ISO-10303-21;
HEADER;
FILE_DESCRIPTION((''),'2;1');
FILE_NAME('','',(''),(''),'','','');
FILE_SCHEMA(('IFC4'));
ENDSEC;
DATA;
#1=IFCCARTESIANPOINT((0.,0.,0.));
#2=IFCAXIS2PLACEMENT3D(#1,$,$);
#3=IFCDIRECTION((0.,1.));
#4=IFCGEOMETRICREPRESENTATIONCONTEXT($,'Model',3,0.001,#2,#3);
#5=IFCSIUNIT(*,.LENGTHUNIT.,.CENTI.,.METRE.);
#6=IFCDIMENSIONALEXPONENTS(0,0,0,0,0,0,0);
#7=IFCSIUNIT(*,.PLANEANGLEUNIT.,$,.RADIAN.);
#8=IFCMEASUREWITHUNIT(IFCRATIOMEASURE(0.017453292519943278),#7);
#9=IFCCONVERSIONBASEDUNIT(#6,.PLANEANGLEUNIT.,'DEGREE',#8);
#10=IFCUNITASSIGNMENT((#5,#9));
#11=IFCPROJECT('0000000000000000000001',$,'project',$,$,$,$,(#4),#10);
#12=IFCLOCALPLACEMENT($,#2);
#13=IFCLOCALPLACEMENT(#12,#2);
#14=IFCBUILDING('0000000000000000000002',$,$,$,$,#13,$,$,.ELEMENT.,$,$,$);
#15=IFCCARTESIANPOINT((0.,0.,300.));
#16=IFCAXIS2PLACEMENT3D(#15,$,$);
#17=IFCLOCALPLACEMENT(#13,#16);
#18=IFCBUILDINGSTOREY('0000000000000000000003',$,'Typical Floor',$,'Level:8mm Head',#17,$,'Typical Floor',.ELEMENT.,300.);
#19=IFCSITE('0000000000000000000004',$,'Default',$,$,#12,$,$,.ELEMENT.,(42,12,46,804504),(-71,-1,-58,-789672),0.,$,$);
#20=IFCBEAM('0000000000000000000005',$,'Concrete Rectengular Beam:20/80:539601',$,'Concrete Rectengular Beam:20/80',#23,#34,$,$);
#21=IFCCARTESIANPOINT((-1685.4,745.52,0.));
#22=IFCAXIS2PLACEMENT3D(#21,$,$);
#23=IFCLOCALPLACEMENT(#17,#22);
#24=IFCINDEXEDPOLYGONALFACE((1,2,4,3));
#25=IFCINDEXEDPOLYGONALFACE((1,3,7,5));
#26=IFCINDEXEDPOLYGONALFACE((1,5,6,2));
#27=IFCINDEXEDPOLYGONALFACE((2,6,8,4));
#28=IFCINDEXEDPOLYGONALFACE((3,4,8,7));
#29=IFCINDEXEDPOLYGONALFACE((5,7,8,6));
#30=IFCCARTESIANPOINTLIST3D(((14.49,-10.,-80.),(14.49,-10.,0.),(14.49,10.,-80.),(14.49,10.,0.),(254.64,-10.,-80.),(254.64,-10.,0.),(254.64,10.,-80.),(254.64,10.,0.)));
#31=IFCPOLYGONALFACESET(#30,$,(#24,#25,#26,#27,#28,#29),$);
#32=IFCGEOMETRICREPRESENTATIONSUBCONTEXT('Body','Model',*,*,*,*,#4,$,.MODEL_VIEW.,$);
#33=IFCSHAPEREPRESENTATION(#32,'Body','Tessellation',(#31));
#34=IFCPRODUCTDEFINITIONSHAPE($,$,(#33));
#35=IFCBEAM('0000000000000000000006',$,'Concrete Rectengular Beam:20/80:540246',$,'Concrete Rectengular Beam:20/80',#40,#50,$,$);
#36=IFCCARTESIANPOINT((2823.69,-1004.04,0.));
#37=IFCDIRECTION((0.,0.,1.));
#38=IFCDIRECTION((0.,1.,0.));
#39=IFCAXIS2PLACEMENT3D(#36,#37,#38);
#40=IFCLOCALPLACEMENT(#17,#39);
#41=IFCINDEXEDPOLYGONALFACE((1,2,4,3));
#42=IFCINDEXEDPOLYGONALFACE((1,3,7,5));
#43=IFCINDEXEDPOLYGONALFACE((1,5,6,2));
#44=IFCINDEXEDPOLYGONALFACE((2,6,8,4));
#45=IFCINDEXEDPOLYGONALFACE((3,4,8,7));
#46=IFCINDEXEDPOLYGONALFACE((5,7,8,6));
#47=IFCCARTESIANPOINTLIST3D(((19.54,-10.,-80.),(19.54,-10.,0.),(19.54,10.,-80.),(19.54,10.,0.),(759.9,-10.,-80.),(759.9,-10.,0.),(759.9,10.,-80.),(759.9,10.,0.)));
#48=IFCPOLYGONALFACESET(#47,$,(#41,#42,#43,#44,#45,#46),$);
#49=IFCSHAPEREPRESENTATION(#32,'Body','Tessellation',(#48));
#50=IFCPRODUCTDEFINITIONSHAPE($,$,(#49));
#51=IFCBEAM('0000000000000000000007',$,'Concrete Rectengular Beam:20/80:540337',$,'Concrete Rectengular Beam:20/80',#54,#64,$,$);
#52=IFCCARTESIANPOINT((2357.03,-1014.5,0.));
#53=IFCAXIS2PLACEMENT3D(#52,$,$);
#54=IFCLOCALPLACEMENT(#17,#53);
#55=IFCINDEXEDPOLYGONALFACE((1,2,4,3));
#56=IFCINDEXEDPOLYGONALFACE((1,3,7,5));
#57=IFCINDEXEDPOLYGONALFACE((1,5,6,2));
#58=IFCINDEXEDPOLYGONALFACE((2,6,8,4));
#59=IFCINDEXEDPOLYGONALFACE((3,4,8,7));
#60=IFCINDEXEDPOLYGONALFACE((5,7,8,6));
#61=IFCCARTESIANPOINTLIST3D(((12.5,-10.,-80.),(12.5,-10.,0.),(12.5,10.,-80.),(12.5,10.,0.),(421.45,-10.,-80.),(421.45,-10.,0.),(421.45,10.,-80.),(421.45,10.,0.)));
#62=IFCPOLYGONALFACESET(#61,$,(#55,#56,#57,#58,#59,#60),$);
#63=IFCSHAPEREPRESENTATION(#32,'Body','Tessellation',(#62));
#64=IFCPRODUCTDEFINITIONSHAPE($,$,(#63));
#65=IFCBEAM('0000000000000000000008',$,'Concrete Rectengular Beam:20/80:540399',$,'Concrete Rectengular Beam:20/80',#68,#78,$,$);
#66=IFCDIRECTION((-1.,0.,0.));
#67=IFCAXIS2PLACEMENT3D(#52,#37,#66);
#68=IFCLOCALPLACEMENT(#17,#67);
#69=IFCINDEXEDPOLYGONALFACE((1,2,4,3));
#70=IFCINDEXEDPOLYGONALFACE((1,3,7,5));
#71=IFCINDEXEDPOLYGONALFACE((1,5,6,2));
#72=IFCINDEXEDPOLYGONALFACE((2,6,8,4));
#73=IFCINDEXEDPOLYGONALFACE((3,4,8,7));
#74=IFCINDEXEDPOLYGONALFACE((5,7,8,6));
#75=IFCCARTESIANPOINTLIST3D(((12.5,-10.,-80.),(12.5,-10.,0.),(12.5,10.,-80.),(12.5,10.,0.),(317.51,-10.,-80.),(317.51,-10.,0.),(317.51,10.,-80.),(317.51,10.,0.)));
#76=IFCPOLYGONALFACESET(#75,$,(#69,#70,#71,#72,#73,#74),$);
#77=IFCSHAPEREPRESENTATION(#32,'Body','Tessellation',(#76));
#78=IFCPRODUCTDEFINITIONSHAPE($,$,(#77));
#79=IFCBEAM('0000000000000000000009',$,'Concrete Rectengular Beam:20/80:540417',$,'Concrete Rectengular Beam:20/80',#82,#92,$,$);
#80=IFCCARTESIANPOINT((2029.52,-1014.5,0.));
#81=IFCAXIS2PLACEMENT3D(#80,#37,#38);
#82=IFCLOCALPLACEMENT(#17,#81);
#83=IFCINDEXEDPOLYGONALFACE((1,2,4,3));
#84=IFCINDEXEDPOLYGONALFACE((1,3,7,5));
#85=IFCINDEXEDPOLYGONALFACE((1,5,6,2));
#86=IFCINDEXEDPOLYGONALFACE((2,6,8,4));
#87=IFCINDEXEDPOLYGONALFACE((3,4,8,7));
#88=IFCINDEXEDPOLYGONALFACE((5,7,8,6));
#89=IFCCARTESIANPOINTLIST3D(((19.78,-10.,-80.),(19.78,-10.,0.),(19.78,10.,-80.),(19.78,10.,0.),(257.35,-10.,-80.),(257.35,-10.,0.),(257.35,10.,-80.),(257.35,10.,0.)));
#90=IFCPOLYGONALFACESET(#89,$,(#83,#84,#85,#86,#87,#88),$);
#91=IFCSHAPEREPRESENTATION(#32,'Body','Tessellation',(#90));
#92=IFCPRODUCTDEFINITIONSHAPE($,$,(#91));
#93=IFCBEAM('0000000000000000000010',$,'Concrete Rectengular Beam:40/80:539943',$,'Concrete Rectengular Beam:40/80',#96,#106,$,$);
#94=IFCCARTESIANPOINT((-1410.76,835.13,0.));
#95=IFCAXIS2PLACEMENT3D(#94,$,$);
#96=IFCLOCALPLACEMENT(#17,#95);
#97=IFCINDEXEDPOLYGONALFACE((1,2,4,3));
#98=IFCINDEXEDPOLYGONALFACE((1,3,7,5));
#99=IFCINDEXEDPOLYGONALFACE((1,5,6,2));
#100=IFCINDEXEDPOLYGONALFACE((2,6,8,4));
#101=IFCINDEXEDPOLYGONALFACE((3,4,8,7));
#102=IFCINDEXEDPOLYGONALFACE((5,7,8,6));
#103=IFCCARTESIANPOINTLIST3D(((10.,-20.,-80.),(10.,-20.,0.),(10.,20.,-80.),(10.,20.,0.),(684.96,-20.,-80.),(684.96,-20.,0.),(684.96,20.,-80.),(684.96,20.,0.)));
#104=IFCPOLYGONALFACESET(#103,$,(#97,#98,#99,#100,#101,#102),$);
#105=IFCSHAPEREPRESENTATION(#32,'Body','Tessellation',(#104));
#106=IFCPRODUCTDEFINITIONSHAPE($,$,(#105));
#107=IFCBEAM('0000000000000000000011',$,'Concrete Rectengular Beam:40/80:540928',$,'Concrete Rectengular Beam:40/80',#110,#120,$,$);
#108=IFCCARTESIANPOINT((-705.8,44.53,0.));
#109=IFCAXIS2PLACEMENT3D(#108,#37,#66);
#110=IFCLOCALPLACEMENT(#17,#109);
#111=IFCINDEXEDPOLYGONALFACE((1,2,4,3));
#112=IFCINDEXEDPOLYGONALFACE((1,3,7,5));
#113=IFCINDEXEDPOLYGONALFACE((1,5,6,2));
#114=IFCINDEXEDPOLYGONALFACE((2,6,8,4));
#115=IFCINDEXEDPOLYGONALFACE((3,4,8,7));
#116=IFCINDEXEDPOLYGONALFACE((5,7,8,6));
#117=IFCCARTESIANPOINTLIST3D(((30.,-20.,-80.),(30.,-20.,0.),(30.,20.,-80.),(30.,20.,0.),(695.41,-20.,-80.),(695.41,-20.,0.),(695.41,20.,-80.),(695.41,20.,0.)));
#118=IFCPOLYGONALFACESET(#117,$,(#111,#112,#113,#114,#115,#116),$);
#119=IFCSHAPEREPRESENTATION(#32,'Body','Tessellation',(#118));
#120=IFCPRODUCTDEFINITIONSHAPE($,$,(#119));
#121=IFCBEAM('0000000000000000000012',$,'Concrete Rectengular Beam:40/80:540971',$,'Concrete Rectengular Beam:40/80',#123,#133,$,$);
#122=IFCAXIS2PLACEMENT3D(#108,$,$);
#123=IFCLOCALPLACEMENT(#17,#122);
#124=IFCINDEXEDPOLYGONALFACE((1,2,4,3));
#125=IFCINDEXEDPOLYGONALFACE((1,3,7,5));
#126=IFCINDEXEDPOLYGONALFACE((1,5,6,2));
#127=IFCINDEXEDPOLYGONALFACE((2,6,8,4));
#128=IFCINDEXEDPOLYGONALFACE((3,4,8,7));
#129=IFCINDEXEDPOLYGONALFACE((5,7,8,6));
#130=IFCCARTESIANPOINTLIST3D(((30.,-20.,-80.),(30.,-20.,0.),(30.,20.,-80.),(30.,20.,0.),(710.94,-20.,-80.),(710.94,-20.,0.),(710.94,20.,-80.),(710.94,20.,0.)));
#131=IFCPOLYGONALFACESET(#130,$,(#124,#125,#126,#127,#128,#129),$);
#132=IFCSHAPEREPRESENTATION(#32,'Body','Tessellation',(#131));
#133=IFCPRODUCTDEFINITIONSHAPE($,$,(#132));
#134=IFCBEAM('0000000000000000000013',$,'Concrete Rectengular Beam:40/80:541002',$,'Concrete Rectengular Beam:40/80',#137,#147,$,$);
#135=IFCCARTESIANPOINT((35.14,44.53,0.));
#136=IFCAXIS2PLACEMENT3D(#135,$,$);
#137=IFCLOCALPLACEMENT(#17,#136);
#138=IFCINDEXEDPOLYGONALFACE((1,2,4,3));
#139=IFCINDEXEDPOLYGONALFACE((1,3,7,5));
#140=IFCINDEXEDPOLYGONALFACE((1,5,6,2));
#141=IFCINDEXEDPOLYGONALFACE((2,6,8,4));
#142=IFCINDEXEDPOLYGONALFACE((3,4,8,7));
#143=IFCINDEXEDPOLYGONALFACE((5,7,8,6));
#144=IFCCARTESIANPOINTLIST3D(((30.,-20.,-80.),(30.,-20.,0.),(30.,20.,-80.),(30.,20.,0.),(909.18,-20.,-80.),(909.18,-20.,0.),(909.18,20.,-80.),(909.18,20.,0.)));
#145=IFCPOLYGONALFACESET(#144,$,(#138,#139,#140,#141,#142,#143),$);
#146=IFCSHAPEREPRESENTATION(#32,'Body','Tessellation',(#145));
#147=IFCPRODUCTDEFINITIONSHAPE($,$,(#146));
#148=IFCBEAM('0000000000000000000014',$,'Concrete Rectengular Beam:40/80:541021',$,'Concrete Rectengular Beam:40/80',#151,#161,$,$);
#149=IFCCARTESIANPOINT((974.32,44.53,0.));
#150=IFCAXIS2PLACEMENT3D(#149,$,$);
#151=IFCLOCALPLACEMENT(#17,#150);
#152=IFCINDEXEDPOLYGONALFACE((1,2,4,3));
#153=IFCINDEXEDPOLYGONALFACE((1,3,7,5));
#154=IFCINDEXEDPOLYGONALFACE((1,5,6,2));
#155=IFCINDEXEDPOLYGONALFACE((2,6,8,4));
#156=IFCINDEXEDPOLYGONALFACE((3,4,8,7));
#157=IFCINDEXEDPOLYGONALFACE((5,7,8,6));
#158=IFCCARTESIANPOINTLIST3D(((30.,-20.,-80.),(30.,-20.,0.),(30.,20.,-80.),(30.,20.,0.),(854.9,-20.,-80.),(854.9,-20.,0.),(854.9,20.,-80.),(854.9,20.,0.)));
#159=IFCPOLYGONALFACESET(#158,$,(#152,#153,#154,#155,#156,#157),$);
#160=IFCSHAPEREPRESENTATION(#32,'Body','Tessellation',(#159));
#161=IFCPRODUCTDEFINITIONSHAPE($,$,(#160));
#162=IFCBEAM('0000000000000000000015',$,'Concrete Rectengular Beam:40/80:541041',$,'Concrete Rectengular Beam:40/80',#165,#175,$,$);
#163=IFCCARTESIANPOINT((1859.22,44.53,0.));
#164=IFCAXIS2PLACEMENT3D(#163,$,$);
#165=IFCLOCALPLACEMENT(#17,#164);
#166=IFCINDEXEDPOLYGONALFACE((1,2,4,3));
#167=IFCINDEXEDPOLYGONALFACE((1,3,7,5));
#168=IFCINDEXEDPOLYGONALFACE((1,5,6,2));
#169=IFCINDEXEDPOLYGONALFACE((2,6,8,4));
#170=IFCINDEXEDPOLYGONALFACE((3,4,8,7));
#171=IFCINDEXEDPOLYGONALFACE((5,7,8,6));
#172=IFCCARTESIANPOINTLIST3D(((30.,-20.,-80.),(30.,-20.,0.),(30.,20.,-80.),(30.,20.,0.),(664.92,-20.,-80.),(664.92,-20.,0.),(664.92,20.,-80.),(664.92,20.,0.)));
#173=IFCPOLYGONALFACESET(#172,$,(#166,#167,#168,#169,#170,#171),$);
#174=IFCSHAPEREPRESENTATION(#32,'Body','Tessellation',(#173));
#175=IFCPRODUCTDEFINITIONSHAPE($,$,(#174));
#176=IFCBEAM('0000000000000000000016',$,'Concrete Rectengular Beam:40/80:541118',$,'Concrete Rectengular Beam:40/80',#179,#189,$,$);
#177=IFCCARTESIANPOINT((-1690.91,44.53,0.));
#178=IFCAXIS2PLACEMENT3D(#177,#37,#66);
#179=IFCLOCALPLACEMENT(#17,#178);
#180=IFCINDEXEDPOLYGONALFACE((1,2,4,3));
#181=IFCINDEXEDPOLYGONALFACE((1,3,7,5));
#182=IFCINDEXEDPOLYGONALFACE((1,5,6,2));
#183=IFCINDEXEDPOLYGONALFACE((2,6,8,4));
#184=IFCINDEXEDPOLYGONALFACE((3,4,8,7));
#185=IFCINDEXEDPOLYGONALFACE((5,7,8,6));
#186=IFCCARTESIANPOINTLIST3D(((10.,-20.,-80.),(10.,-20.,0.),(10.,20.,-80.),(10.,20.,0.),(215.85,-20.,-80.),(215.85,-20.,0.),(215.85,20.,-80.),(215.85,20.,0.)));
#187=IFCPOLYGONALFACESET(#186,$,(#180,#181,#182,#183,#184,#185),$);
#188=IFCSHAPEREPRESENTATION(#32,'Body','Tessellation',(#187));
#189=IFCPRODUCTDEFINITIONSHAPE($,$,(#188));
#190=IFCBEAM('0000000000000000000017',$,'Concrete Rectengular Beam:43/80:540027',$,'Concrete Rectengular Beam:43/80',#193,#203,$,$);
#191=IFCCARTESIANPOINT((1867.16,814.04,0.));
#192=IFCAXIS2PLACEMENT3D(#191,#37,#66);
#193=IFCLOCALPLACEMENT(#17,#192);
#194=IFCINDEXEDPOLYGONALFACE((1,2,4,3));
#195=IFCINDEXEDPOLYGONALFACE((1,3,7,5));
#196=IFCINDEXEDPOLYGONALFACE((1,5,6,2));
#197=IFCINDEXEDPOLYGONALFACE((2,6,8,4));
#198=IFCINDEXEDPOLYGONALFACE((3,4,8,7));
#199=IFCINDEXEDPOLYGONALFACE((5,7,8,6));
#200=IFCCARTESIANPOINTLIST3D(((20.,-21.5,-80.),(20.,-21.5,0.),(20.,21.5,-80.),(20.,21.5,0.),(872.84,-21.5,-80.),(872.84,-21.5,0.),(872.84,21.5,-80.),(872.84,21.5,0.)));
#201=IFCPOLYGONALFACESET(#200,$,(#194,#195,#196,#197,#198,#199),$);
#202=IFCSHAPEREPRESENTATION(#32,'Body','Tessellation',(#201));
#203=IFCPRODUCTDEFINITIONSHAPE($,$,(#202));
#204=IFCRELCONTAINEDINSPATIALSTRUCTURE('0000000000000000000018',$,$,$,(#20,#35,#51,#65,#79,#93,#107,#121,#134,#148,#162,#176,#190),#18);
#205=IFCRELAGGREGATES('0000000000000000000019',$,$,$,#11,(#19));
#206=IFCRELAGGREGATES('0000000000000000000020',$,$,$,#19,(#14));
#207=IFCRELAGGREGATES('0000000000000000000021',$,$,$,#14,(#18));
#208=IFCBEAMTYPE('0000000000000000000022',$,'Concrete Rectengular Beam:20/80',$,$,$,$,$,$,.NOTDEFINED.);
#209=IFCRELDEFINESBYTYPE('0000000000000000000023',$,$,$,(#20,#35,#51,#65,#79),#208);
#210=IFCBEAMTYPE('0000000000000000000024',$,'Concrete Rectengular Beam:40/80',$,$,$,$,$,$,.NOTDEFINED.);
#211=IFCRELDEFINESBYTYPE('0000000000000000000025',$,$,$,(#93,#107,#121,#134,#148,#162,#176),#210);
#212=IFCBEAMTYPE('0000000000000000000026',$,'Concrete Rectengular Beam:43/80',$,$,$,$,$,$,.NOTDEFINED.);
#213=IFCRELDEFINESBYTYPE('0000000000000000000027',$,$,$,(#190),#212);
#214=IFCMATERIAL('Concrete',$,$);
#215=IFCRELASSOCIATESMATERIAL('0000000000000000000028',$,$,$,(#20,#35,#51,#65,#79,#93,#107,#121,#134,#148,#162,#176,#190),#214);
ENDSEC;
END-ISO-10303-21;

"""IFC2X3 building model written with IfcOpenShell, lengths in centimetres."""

from ifc_helpers import new_model, entity, si_unit, converted_unit, direction, frame, frame_2d, origin, place, context, subcontext, project, spatial, rectangle, extrude, material, type_object, element, save


model = new_model("IFC2X3")

# Units and contexts
model_context = context("Model", 3, precision=0.001, world=origin(), true_north=direction((0.0, 1.0)))
body_context = subcontext(model_context, "Body", "Model", "MODEL_VIEW")
ifc_project = project(units=[si_unit("LENGTHUNIT", "METRE", prefix="CENTI"), converted_unit("PLANEANGLEUNIT", "DEGREE", entity("IfcRatioMeasure", 0.017453292519943278), si_unit("PLANEANGLEUNIT", "RADIAN"), dimensions=[0, 0, 0, 0, 0, 0, 0])], contexts=[model_context])

# Site, building, storey
site_placement = place(None, origin())
site = spatial("IfcSite", under=ifc_project, at=site_placement, Name="Default", CompositionType="ELEMENT", RefLatitude=(42, 12, 46, 804504), RefLongitude=(-71, -1, -58, -789672), RefElevation=0.0)
building_placement = place(site_placement, origin())
building = spatial("IfcBuilding", under=site, at=building_placement, CompositionType="ELEMENT")
storey_placement = place(building_placement, frame((0.0, 0.0, 300.0)))
storey = spatial("IfcBuildingStorey", under=building, at=storey_placement, Name="Typical Floor", ObjectType="Level:8mm Head", LongName="Typical Floor", CompositionType="ELEMENT", Elevation=300.0)

# Beams
ifc_material = material(Name="Concrete")
beam_type_1 = type_object("IfcBeamType", Name="Concrete Rectengular Beam:20/80", PredefinedType="NOTDEFINED")
beam_1_placement = place(storey_placement, frame((-1685.4, 745.52, 0.0)))
element("IfcBeam", 1, at=beam_1_placement, inside=storey, type_object=beam_type_1, material=ifc_material, Name="Concrete Rectengular Beam:20/80:539601", ObjectType="Concrete Rectengular Beam:20/80", context=body_context, shape_type="SweptSolid", body=[
    extrude(rectangle(XDim=80.0, YDim=20.0, at=frame_2d((0.0, 0.0), x_axis=(1.0, 0.0))), frame((14.49, 0.0, -40.0), z_axis=(1.0, 0.0, 0.0), x_axis=(0.0, 0.0, -1.0)), (0.0, 0.0, 1.0), 240.15),
])
beam_2_placement = place(storey_placement, frame((2823.69, -1004.04, 0.0), z_axis=(0.0, 0.0, 1.0), x_axis=(0.0, 1.0, 0.0)))
element("IfcBeam", 2, at=beam_2_placement, inside=storey, type_object=beam_type_1, material=ifc_material, Name="Concrete Rectengular Beam:20/80:540246", ObjectType="Concrete Rectengular Beam:20/80", context=body_context, shape_type="SweptSolid", body=[
    extrude(rectangle(XDim=80.0, YDim=20.0, at=frame_2d((0.0, 0.0), x_axis=(1.0, 0.0))), frame((19.54, 0.0, -40.0), z_axis=(1.0, 0.0, 0.0), x_axis=(0.0, 0.0, -1.0)), (0.0, 0.0, 1.0), 740.36),
])
beam_3_placement = place(storey_placement, frame((2357.03, -1014.5, 0.0)))
element("IfcBeam", 3, at=beam_3_placement, inside=storey, type_object=beam_type_1, material=ifc_material, Name="Concrete Rectengular Beam:20/80:540337", ObjectType="Concrete Rectengular Beam:20/80", context=body_context, shape_type="SweptSolid", body=[
    extrude(rectangle(XDim=80.0, YDim=20.0, at=frame_2d((0.0, 0.0), x_axis=(1.0, 0.0))), frame((12.5, 0.0, -40.0), z_axis=(1.0, 0.0, 0.0), x_axis=(0.0, 0.0, -1.0)), (0.0, 0.0, 1.0), 408.95),
])
beam_4_placement = place(storey_placement, frame((2357.03, -1014.5, 0.0), z_axis=(0.0, 0.0, 1.0), x_axis=(-1.0, 0.0, 0.0)))
element("IfcBeam", 4, at=beam_4_placement, inside=storey, type_object=beam_type_1, material=ifc_material, Name="Concrete Rectengular Beam:20/80:540399", ObjectType="Concrete Rectengular Beam:20/80", context=body_context, shape_type="SweptSolid", body=[
    extrude(rectangle(XDim=80.0, YDim=20.0, at=frame_2d((0.0, 0.0), x_axis=(1.0, 0.0))), frame((12.5, 0.0, -40.0), z_axis=(1.0, 0.0, 0.0), x_axis=(0.0, 0.0, -1.0)), (0.0, 0.0, 1.0), 305.01),
])
beam_5_placement = place(storey_placement, frame((2029.52, -1014.5, 0.0), z_axis=(0.0, 0.0, 1.0), x_axis=(0.0, 1.0, 0.0)))
element("IfcBeam", 5, at=beam_5_placement, inside=storey, type_object=beam_type_1, material=ifc_material, Name="Concrete Rectengular Beam:20/80:540417", ObjectType="Concrete Rectengular Beam:20/80", context=body_context, shape_type="SweptSolid", body=[
    extrude(rectangle(XDim=80.0, YDim=20.0, at=frame_2d((0.0, 0.0), x_axis=(1.0, 0.0))), frame((19.78, 0.0, -40.0), z_axis=(1.0, 0.0, 0.0), x_axis=(0.0, 0.0, -1.0)), (0.0, 0.0, 1.0), 237.58),
])
beam_type_2 = type_object("IfcBeamType", Name="Concrete Rectengular Beam:40/80", PredefinedType="NOTDEFINED")
beam_6_placement = place(storey_placement, frame((-1410.76, 835.13, 0.0)))
element("IfcBeam", 6, at=beam_6_placement, inside=storey, type_object=beam_type_2, material=ifc_material, Name="Concrete Rectengular Beam:40/80:539943", ObjectType="Concrete Rectengular Beam:40/80", context=body_context, shape_type="SweptSolid", body=[
    extrude(rectangle(XDim=80.0, YDim=40.0, at=frame_2d((0.0, 0.0), x_axis=(1.0, 0.0))), frame((10.0, 0.0, -40.0), z_axis=(1.0, 0.0, 0.0), x_axis=(0.0, 0.0, -1.0)), (0.0, 0.0, 1.0), 674.96),
])
beam_7_placement = place(storey_placement, frame((-705.8, 44.53, 0.0), z_axis=(0.0, 0.0, 1.0), x_axis=(-1.0, 0.0, 0.0)))
element("IfcBeam", 7, at=beam_7_placement, inside=storey, type_object=beam_type_2, material=ifc_material, Name="Concrete Rectengular Beam:40/80:540928", ObjectType="Concrete Rectengular Beam:40/80", context=body_context, shape_type="SweptSolid", body=[
    extrude(rectangle(XDim=80.0, YDim=40.0, at=frame_2d((0.0, 0.0), x_axis=(1.0, 0.0))), frame((30.0, 0.0, -40.0), z_axis=(1.0, 0.0, 0.0), x_axis=(0.0, 0.0, -1.0)), (0.0, 0.0, 1.0), 665.41),
])
beam_8_placement = place(storey_placement, frame((-705.8, 44.53, 0.0)))
element("IfcBeam", 8, at=beam_8_placement, inside=storey, type_object=beam_type_2, material=ifc_material, Name="Concrete Rectengular Beam:40/80:540971", ObjectType="Concrete Rectengular Beam:40/80", context=body_context, shape_type="SweptSolid", body=[
    extrude(rectangle(XDim=80.0, YDim=40.0, at=frame_2d((0.0, 0.0), x_axis=(1.0, 0.0))), frame((30.0, 0.0, -40.0), z_axis=(1.0, 0.0, 0.0), x_axis=(0.0, 0.0, -1.0)), (0.0, 0.0, 1.0), 680.94),
])
beam_9_placement = place(storey_placement, frame((35.14, 44.53, 0.0)))
element("IfcBeam", 9, at=beam_9_placement, inside=storey, type_object=beam_type_2, material=ifc_material, Name="Concrete Rectengular Beam:40/80:541002", ObjectType="Concrete Rectengular Beam:40/80", context=body_context, shape_type="SweptSolid", body=[
    extrude(rectangle(XDim=80.0, YDim=40.0, at=frame_2d((0.0, 0.0), x_axis=(1.0, 0.0))), frame((30.0, 0.0, -40.0), z_axis=(1.0, 0.0, 0.0), x_axis=(0.0, 0.0, -1.0)), (0.0, 0.0, 1.0), 879.18),
])
beam_10_placement = place(storey_placement, frame((974.32, 44.53, 0.0)))
element("IfcBeam", 10, at=beam_10_placement, inside=storey, type_object=beam_type_2, material=ifc_material, Name="Concrete Rectengular Beam:40/80:541021", ObjectType="Concrete Rectengular Beam:40/80", context=body_context, shape_type="SweptSolid", body=[
    extrude(rectangle(XDim=80.0, YDim=40.0, at=frame_2d((0.0, 0.0), x_axis=(1.0, 0.0))), frame((30.0, 0.0, -40.0), z_axis=(1.0, 0.0, 0.0), x_axis=(0.0, 0.0, -1.0)), (0.0, 0.0, 1.0), 824.9),
])
beam_11_placement = place(storey_placement, frame((1859.22, 44.53, 0.0)))
element("IfcBeam", 11, at=beam_11_placement, inside=storey, type_object=beam_type_2, material=ifc_material, Name="Concrete Rectengular Beam:40/80:541041", ObjectType="Concrete Rectengular Beam:40/80", context=body_context, shape_type="SweptSolid", body=[
    extrude(rectangle(XDim=80.0, YDim=40.0, at=frame_2d((0.0, 0.0), x_axis=(1.0, 0.0))), frame((30.0, 0.0, -40.0), z_axis=(1.0, 0.0, 0.0), x_axis=(0.0, 0.0, -1.0)), (0.0, 0.0, 1.0), 634.92),
])
beam_12_placement = place(storey_placement, frame((-1690.91, 44.53, 0.0), z_axis=(0.0, 0.0, 1.0), x_axis=(-1.0, 0.0, 0.0)))
element("IfcBeam", 12, at=beam_12_placement, inside=storey, type_object=beam_type_2, material=ifc_material, Name="Concrete Rectengular Beam:40/80:541118", ObjectType="Concrete Rectengular Beam:40/80", context=body_context, shape_type="SweptSolid", body=[
    extrude(rectangle(XDim=80.0, YDim=40.0, at=frame_2d((0.0, 0.0), x_axis=(1.0, 0.0))), frame((10.0, 0.0, -40.0), z_axis=(1.0, 0.0, 0.0), x_axis=(0.0, 0.0, -1.0)), (0.0, 0.0, 1.0), 205.85),
])
beam_type_3 = type_object("IfcBeamType", Name="Concrete Rectengular Beam:43/80", PredefinedType="NOTDEFINED")
beam_13_placement = place(storey_placement, frame((1867.16, 814.04, 0.0), z_axis=(0.0, 0.0, 1.0), x_axis=(-1.0, 0.0, 0.0)))
element("IfcBeam", 13, at=beam_13_placement, inside=storey, type_object=beam_type_3, material=ifc_material, Name="Concrete Rectengular Beam:43/80:540027", ObjectType="Concrete Rectengular Beam:43/80", context=body_context, shape_type="SweptSolid", body=[
    extrude(rectangle(XDim=80.0, YDim=43.0, at=frame_2d((0.0, 0.0), x_axis=(1.0, 0.0))), frame((20.0, 0.0, -40.0), z_axis=(1.0, 0.0, 0.0), x_axis=(0.0, 0.0, -1.0)), (0.0, 0.0, 1.0), 852.84),
])

save(model, "model.ifc")
